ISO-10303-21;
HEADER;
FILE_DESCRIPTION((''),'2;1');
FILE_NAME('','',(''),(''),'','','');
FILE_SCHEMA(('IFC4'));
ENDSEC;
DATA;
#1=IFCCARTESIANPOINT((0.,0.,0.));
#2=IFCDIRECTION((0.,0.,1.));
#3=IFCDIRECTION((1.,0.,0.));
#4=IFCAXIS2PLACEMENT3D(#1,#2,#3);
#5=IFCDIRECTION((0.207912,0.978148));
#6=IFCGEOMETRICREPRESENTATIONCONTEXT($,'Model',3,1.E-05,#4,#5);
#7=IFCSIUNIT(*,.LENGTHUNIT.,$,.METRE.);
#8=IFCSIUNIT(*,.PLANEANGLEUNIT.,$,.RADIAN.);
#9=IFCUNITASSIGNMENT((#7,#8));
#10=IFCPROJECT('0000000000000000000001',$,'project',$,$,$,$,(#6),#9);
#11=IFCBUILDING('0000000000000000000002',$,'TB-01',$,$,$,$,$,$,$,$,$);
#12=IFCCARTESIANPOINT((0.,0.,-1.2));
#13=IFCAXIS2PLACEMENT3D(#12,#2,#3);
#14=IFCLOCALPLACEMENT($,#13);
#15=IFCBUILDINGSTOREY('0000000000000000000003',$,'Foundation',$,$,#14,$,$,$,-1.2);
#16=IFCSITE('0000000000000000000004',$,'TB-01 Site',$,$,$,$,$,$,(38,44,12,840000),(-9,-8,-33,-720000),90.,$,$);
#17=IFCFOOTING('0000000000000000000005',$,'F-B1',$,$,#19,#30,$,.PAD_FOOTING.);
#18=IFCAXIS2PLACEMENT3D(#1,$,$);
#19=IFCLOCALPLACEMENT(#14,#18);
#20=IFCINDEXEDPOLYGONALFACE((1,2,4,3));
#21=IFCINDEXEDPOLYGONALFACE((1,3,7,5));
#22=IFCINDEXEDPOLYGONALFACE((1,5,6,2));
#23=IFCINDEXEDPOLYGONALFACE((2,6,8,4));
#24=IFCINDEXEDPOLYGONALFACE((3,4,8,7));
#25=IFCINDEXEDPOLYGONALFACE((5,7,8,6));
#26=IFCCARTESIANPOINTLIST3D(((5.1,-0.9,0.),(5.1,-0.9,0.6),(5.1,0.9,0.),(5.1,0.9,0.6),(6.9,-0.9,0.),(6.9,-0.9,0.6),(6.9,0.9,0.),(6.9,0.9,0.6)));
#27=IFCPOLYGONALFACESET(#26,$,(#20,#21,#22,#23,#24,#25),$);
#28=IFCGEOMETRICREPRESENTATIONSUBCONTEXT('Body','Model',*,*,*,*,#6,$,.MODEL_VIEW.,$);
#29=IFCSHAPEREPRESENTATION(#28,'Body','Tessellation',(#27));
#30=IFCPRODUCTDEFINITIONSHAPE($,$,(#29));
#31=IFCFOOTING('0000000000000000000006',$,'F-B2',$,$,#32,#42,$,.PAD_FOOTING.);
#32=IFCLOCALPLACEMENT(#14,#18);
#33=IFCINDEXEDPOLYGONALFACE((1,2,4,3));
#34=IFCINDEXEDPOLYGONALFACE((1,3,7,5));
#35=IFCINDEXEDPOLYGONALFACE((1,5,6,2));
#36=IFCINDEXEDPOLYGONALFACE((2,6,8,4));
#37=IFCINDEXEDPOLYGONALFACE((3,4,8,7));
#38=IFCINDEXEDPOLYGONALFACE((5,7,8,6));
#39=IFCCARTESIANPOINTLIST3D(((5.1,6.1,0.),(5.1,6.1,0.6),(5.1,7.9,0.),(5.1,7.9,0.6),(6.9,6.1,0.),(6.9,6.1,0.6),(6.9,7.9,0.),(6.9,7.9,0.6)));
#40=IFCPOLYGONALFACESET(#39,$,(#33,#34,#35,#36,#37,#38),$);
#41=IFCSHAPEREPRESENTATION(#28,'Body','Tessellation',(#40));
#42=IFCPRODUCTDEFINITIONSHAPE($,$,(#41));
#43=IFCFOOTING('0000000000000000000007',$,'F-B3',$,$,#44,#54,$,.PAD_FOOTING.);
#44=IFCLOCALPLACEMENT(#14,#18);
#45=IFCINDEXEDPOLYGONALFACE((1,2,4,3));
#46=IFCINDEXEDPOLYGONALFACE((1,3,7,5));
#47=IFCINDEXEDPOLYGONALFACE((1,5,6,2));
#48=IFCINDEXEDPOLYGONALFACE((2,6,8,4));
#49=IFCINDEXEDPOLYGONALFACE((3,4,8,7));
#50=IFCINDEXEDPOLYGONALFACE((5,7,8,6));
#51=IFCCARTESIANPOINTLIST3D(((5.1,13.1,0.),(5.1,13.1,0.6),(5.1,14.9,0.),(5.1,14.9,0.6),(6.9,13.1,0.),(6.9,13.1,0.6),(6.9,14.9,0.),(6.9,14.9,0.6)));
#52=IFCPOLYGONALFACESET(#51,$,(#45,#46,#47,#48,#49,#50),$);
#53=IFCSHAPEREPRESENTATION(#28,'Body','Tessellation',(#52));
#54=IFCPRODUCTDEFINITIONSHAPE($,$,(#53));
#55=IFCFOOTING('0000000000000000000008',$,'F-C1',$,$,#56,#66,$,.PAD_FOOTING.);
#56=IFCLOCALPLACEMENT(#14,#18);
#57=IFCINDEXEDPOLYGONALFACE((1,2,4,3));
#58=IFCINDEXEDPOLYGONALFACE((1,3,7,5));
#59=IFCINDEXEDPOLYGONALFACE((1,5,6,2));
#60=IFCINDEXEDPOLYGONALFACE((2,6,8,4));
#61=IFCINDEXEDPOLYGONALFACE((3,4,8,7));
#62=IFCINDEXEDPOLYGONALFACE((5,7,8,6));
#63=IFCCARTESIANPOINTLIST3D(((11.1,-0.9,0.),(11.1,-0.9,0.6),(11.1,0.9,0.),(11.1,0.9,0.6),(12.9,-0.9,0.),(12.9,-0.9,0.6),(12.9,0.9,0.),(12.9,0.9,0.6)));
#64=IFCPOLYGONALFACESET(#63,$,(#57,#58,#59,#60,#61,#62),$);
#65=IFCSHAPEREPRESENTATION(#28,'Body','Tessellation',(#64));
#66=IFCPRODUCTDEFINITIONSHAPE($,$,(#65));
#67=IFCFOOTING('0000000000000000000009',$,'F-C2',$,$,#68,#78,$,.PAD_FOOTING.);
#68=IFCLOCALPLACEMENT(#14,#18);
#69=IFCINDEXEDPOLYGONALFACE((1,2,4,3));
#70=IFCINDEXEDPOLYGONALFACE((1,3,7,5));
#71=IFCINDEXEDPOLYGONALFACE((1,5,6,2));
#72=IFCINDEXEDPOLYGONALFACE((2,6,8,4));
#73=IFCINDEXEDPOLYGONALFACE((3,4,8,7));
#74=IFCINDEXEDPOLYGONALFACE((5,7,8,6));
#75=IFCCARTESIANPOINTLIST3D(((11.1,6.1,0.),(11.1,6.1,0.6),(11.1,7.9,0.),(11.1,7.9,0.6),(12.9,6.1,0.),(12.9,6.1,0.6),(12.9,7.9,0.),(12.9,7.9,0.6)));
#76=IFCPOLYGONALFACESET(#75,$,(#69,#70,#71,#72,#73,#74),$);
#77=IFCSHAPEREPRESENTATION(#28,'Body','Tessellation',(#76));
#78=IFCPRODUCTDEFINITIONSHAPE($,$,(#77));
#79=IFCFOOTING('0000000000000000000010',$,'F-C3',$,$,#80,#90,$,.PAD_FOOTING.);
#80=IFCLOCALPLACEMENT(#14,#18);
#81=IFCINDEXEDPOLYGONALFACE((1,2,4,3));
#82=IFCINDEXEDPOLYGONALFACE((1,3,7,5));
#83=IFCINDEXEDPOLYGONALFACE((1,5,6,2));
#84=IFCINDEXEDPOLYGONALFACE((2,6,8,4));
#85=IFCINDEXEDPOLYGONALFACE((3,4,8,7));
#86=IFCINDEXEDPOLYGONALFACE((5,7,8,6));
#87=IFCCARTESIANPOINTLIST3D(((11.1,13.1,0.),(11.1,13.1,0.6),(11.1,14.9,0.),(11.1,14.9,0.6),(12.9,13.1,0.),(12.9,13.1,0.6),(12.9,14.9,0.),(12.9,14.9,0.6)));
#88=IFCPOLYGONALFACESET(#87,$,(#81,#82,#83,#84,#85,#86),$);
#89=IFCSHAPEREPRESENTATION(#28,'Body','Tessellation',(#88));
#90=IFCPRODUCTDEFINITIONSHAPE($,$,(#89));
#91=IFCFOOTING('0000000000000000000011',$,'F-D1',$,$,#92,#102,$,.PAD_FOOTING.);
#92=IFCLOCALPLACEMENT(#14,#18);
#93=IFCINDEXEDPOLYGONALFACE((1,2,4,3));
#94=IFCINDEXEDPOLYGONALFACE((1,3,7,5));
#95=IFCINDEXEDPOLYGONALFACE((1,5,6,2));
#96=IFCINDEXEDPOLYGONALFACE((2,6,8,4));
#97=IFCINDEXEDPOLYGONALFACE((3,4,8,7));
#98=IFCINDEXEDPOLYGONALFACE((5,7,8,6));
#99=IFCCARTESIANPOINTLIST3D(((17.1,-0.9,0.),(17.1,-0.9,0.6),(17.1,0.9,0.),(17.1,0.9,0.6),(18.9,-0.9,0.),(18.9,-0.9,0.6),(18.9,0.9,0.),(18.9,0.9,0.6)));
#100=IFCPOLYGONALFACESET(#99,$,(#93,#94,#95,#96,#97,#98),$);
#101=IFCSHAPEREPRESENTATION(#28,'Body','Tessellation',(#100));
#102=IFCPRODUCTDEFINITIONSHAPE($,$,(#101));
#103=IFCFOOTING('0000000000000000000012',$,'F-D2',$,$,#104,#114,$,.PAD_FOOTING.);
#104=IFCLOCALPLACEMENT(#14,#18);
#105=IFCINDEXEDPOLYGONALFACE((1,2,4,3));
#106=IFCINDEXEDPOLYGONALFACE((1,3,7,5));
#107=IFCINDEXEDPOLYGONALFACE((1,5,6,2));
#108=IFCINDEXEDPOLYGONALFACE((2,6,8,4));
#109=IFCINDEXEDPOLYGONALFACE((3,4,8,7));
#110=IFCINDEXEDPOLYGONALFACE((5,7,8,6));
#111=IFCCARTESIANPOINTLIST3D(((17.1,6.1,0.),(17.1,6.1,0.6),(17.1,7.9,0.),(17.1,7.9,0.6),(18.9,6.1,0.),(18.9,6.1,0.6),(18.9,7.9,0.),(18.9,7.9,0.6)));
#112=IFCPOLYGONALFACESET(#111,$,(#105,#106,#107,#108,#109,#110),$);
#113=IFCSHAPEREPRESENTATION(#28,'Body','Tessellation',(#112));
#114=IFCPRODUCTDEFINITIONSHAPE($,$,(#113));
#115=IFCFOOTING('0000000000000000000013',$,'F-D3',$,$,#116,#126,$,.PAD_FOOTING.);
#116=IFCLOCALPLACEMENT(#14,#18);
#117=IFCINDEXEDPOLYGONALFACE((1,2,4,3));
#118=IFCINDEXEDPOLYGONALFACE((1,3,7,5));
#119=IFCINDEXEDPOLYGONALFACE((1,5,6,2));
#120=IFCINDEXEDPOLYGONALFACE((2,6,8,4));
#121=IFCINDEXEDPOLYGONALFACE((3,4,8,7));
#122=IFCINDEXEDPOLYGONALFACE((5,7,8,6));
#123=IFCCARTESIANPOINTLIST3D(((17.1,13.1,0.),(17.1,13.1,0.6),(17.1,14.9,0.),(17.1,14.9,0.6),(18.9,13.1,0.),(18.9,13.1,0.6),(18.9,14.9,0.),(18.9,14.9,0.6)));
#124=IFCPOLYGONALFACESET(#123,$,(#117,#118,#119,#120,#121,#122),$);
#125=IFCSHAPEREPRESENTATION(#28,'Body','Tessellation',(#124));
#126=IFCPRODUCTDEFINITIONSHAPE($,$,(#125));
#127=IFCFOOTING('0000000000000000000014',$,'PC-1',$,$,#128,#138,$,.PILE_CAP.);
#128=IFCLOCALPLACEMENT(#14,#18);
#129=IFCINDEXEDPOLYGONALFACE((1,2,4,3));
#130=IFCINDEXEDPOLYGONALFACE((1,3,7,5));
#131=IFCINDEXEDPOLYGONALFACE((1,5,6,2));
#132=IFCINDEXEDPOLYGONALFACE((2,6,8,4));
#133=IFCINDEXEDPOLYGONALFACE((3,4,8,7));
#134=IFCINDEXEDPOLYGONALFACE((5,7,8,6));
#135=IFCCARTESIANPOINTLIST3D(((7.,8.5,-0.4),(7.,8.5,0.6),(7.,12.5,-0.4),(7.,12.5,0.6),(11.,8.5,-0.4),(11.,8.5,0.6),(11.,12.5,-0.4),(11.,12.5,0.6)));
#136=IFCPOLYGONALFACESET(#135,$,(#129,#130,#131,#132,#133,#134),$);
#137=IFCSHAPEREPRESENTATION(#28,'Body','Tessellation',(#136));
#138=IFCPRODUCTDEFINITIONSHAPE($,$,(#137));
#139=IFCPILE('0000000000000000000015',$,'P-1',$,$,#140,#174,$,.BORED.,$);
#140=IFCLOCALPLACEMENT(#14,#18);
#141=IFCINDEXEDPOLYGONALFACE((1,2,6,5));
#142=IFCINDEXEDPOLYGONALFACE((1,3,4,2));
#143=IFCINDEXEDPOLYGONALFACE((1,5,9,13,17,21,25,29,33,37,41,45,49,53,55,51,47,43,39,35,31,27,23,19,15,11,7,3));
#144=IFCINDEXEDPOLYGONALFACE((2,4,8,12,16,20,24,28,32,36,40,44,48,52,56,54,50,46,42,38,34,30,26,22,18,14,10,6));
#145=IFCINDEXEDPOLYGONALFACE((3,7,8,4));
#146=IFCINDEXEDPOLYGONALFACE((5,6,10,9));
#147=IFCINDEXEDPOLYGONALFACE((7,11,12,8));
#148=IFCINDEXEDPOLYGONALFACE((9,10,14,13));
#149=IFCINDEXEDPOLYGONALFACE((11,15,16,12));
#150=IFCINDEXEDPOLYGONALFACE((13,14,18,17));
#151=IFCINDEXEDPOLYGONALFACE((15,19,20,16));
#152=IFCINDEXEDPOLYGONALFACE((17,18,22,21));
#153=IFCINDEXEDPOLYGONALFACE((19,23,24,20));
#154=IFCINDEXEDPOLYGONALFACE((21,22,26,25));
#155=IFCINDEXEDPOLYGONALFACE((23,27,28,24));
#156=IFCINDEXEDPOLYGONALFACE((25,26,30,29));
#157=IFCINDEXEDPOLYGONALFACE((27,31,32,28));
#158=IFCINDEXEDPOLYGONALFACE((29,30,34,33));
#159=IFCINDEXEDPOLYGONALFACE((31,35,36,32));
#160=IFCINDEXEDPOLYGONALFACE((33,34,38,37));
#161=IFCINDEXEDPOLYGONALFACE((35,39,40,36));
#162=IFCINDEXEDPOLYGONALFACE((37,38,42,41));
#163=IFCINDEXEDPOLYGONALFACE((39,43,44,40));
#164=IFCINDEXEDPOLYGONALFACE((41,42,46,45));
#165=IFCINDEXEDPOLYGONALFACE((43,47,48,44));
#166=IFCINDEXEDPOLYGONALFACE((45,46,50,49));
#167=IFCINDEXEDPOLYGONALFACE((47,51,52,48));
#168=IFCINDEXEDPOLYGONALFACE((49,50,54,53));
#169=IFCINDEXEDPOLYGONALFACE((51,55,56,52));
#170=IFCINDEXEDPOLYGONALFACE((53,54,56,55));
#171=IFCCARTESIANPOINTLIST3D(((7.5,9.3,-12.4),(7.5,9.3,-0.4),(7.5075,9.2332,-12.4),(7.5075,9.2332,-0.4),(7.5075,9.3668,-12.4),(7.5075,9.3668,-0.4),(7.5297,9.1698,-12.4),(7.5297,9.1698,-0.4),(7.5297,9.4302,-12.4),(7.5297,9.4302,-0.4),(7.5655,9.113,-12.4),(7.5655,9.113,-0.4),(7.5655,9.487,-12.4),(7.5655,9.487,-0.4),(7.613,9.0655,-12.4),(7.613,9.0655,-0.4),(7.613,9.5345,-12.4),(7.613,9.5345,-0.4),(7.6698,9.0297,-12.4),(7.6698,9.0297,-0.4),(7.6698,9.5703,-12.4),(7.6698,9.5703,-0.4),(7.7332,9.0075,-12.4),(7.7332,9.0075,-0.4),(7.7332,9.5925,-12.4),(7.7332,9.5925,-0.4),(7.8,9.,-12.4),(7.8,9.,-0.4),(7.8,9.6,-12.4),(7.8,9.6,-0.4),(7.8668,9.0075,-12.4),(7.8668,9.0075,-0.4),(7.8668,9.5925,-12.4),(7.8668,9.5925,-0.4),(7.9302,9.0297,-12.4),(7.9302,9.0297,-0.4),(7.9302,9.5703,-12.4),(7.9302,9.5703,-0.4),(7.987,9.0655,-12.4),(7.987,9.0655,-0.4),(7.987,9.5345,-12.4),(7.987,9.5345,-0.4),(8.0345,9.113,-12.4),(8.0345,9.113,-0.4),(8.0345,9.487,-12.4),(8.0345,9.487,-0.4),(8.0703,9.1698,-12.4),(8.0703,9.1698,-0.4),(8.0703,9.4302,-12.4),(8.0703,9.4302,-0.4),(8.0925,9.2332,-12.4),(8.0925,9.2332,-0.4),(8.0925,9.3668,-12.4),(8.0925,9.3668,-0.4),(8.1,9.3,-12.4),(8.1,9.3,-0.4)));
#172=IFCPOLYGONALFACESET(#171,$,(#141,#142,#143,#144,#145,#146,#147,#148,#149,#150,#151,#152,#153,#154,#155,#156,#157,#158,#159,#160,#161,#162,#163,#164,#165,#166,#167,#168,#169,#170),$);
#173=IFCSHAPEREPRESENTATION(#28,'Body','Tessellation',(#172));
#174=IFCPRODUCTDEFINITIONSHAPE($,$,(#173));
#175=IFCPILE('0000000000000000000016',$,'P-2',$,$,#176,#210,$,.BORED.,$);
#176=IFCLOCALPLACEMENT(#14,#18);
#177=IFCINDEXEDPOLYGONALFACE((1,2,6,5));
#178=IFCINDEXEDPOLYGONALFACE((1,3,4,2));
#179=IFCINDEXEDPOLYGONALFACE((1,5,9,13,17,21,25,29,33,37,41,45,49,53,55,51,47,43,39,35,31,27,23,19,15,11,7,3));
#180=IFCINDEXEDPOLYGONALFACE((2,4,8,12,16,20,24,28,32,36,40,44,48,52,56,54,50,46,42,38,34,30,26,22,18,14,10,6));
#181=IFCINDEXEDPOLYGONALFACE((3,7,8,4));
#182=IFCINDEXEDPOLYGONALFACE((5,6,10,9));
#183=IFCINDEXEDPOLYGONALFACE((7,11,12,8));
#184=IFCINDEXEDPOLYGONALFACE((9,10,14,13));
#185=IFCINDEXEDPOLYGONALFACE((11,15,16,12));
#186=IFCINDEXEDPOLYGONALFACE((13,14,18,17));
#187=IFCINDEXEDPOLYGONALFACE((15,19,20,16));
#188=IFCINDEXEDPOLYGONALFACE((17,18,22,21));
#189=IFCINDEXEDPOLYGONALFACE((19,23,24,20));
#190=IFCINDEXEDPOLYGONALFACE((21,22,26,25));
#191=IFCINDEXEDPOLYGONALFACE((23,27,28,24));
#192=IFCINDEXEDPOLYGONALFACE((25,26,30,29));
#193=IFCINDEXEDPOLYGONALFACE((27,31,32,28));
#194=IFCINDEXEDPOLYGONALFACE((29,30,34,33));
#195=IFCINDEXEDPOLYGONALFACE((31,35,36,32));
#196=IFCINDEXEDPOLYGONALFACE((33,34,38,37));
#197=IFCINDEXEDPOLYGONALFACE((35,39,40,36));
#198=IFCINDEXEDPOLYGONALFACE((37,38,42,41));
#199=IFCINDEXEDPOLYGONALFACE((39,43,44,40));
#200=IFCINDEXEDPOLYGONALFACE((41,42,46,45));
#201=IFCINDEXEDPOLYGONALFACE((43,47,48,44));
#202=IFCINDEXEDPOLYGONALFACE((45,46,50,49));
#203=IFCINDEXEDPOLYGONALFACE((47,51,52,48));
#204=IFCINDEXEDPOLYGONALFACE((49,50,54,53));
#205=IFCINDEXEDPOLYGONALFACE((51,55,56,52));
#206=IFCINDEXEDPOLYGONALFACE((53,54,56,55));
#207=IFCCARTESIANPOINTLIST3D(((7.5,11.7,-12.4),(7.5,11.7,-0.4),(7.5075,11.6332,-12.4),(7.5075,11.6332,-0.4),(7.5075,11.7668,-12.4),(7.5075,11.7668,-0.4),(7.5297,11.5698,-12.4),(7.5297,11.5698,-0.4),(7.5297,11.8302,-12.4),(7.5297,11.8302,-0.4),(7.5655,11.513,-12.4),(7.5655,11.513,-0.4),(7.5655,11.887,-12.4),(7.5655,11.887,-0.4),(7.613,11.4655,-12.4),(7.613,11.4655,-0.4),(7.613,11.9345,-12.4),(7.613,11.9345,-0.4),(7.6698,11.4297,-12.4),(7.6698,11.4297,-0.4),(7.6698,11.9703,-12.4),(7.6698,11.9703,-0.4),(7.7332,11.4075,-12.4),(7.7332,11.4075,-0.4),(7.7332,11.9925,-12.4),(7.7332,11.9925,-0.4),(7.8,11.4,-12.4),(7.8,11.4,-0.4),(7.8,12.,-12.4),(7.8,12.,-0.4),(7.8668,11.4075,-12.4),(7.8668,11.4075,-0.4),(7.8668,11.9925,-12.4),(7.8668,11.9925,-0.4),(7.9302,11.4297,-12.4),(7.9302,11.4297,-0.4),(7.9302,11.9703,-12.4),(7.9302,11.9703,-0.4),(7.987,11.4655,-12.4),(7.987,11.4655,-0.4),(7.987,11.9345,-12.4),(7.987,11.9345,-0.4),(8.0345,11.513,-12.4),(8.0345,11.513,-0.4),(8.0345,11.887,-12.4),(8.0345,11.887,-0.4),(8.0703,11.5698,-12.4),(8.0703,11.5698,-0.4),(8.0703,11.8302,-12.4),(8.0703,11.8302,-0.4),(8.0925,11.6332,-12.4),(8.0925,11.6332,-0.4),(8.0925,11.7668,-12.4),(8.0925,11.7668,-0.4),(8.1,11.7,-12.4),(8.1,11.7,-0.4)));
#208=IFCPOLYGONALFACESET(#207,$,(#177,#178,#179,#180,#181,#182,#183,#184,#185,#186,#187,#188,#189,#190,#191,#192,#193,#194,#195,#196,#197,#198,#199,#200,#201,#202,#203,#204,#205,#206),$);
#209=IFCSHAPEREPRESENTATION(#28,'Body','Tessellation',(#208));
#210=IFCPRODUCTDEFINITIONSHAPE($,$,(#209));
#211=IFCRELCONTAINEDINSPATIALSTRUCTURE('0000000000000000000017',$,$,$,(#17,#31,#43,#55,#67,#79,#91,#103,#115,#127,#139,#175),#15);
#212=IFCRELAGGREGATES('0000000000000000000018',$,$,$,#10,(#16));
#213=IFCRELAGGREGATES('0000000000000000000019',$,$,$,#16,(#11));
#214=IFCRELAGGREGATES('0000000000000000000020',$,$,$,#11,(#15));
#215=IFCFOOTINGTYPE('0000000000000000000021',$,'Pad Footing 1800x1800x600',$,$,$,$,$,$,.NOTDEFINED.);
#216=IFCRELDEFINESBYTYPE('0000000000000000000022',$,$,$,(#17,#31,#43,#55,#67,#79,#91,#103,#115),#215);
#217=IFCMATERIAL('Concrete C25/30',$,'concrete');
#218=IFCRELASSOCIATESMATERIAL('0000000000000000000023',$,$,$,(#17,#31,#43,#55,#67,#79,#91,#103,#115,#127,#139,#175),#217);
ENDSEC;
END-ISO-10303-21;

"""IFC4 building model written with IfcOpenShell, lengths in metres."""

from ifc_helpers import new_model, si_unit, direction, frame, origin_with_axes, place, context, subcontext, project, spatial, rectangle, circle, extrude, material, type_object, element, save


model = new_model("IFC4")

# Units and contexts
model_context = context("Model", 3, precision=1e-05, world=origin_with_axes(), true_north=direction((0.207912, 0.978148)))
body_context = subcontext(model_context, "Body", "Model", "MODEL_VIEW")
ifc_project = project(units=[si_unit("LENGTHUNIT", "METRE"), si_unit("PLANEANGLEUNIT", "RADIAN")], contexts=[model_context])

# Site, building, storey
site = spatial("IfcSite", under=ifc_project, Name="TB-01 Site", RefLatitude=(38, 44, 12, 840000), RefLongitude=(-9, -8, -33, -720000), RefElevation=90.0)
building = spatial("IfcBuilding", under=site, Name="TB-01")
storey_placement = place(None, frame((0.0, 0.0, -1.2), z_axis=(0.0, 0.0, 1.0), x_axis=(1.0, 0.0, 0.0)))
storey = spatial("IfcBuildingStorey", under=building, at=storey_placement, Name="Foundation", Elevation=-1.2)

# Footings
ifc_material_1 = material(Name="Concrete C25/30", Category="concrete")
footing_type = type_object("IfcFootingType", Name="Pad Footing 1800x1800x600", PredefinedType="NOTDEFINED")
footing_1_placement = place(storey_placement, frame((6.0, 0.0, 0.0), z_axis=(0.0, 0.0, 1.0), x_axis=(1.0, 0.0, 0.0)))
element("IfcFooting", 1, at=footing_1_placement, inside=storey, type_object=footing_type, material=ifc_material_1, Name="F-B1", PredefinedType="PAD_FOOTING", context=body_context, shape_type="SweptSolid", body=[
    extrude(rectangle(XDim=1.8, YDim=1.8), origin_with_axes(), (0.0, 0.0, 1.0), 0.6),
])
for number, where, z_axis, x_axis, name in (
    (2, (6.0, 7.0, 0.0), (0.0, 0.0, 1.0), (1.0, 0.0, 0.0), "F-B2"),
    (3, (6.0, 14.0, 0.0), (0.0, 0.0, 1.0), (1.0, 0.0, 0.0), "F-B3"),
):
    element("IfcFooting", number, at=place(storey_placement, frame(where, z_axis=z_axis, x_axis=x_axis)), inside=storey, type_object=footing_type, material=ifc_material_1, Name=name, PredefinedType="PAD_FOOTING", context=body_context, shape_type="SweptSolid", body=[
        extrude(rectangle(XDim=1.8, YDim=1.8), origin_with_axes(), (0.0, 0.0, 1.0), 0.6),
    ])
footing_2_placement = place(storey_placement, frame((12.0, 0.0, 0.0), z_axis=(0.0, 0.0, 1.0), x_axis=(1.0, 0.0, 0.0)))
element("IfcFooting", 4, at=footing_2_placement, inside=storey, type_object=footing_type, material=ifc_material_1, Name="F-C1", PredefinedType="PAD_FOOTING", context=body_context, shape_type="SweptSolid", body=[
    extrude(rectangle(XDim=1.8, YDim=1.8), origin_with_axes(), (0.0, 0.0, 1.0), 0.6),
])
for number, where, z_axis, x_axis, name in (
    (5, (12.0, 7.0, 0.0), (0.0, 0.0, 1.0), (1.0, 0.0, 0.0), "F-C2"),
    (6, (12.0, 14.0, 0.0), (0.0, 0.0, 1.0), (1.0, 0.0, 0.0), "F-C3"),
):
    element("IfcFooting", number, at=place(storey_placement, frame(where, z_axis=z_axis, x_axis=x_axis)), inside=storey, type_object=footing_type, material=ifc_material_1, Name=name, PredefinedType="PAD_FOOTING", context=body_context, shape_type="SweptSolid", body=[
        extrude(rectangle(XDim=1.8, YDim=1.8), origin_with_axes(), (0.0, 0.0, 1.0), 0.6),
    ])
footing_3_placement = place(storey_placement, frame((18.0, 0.0, 0.0), z_axis=(0.0, 0.0, 1.0), x_axis=(1.0, 0.0, 0.0)))
element("IfcFooting", 7, at=footing_3_placement, inside=storey, type_object=footing_type, material=ifc_material_1, Name="F-D1", PredefinedType="PAD_FOOTING", context=body_context, shape_type="SweptSolid", body=[
    extrude(rectangle(XDim=1.8, YDim=1.8), origin_with_axes(), (0.0, 0.0, 1.0), 0.6),
])
for number, where, z_axis, x_axis, name in (
    (8, (18.0, 7.0, 0.0), (0.0, 0.0, 1.0), (1.0, 0.0, 0.0), "F-D2"),
    (9, (18.0, 14.0, 0.0), (0.0, 0.0, 1.0), (1.0, 0.0, 0.0), "F-D3"),
):
    element("IfcFooting", number, at=place(storey_placement, frame(where, z_axis=z_axis, x_axis=x_axis)), inside=storey, type_object=footing_type, material=ifc_material_1, Name=name, PredefinedType="PAD_FOOTING", context=body_context, shape_type="SweptSolid", body=[
        extrude(rectangle(XDim=1.8, YDim=1.8), origin_with_axes(), (0.0, 0.0, 1.0), 0.6),
    ])
footing_4_placement = place(storey_placement, frame((9.0, 10.5, -0.4), z_axis=(0.0, 0.0, 1.0), x_axis=(1.0, 0.0, 0.0)))
element("IfcFooting", 10, at=footing_4_placement, inside=storey, material=ifc_material_1, Name="PC-1", PredefinedType="PILE_CAP", context=body_context, shape_type="SweptSolid", body=[
    extrude(rectangle(XDim=4.0, YDim=4.0), origin_with_axes(), (0.0, 0.0, 1.0), 1.0),
])

# Piles
for number, where, z_axis, x_axis, name in (
    (11, (7.8, 9.3, -12.4), (0.0, 0.0, 1.0), (1.0, 0.0, 0.0), "P-1"),
    (12, (7.8, 11.7, -12.4), (0.0, 0.0, 1.0), (1.0, 0.0, 0.0), "P-2"),
):
    element("IfcPile", number, at=place(storey_placement, frame(where, z_axis=z_axis, x_axis=x_axis)), inside=storey, material=ifc_material_1, Name=name, PredefinedType="BORED", context=body_context, shape_type="SweptSolid", body=[
        extrude(circle(Radius=0.3), origin_with_axes(), (0.0, 0.0, 1.0), 12.0),
    ])

save(model, "model.ifc")
